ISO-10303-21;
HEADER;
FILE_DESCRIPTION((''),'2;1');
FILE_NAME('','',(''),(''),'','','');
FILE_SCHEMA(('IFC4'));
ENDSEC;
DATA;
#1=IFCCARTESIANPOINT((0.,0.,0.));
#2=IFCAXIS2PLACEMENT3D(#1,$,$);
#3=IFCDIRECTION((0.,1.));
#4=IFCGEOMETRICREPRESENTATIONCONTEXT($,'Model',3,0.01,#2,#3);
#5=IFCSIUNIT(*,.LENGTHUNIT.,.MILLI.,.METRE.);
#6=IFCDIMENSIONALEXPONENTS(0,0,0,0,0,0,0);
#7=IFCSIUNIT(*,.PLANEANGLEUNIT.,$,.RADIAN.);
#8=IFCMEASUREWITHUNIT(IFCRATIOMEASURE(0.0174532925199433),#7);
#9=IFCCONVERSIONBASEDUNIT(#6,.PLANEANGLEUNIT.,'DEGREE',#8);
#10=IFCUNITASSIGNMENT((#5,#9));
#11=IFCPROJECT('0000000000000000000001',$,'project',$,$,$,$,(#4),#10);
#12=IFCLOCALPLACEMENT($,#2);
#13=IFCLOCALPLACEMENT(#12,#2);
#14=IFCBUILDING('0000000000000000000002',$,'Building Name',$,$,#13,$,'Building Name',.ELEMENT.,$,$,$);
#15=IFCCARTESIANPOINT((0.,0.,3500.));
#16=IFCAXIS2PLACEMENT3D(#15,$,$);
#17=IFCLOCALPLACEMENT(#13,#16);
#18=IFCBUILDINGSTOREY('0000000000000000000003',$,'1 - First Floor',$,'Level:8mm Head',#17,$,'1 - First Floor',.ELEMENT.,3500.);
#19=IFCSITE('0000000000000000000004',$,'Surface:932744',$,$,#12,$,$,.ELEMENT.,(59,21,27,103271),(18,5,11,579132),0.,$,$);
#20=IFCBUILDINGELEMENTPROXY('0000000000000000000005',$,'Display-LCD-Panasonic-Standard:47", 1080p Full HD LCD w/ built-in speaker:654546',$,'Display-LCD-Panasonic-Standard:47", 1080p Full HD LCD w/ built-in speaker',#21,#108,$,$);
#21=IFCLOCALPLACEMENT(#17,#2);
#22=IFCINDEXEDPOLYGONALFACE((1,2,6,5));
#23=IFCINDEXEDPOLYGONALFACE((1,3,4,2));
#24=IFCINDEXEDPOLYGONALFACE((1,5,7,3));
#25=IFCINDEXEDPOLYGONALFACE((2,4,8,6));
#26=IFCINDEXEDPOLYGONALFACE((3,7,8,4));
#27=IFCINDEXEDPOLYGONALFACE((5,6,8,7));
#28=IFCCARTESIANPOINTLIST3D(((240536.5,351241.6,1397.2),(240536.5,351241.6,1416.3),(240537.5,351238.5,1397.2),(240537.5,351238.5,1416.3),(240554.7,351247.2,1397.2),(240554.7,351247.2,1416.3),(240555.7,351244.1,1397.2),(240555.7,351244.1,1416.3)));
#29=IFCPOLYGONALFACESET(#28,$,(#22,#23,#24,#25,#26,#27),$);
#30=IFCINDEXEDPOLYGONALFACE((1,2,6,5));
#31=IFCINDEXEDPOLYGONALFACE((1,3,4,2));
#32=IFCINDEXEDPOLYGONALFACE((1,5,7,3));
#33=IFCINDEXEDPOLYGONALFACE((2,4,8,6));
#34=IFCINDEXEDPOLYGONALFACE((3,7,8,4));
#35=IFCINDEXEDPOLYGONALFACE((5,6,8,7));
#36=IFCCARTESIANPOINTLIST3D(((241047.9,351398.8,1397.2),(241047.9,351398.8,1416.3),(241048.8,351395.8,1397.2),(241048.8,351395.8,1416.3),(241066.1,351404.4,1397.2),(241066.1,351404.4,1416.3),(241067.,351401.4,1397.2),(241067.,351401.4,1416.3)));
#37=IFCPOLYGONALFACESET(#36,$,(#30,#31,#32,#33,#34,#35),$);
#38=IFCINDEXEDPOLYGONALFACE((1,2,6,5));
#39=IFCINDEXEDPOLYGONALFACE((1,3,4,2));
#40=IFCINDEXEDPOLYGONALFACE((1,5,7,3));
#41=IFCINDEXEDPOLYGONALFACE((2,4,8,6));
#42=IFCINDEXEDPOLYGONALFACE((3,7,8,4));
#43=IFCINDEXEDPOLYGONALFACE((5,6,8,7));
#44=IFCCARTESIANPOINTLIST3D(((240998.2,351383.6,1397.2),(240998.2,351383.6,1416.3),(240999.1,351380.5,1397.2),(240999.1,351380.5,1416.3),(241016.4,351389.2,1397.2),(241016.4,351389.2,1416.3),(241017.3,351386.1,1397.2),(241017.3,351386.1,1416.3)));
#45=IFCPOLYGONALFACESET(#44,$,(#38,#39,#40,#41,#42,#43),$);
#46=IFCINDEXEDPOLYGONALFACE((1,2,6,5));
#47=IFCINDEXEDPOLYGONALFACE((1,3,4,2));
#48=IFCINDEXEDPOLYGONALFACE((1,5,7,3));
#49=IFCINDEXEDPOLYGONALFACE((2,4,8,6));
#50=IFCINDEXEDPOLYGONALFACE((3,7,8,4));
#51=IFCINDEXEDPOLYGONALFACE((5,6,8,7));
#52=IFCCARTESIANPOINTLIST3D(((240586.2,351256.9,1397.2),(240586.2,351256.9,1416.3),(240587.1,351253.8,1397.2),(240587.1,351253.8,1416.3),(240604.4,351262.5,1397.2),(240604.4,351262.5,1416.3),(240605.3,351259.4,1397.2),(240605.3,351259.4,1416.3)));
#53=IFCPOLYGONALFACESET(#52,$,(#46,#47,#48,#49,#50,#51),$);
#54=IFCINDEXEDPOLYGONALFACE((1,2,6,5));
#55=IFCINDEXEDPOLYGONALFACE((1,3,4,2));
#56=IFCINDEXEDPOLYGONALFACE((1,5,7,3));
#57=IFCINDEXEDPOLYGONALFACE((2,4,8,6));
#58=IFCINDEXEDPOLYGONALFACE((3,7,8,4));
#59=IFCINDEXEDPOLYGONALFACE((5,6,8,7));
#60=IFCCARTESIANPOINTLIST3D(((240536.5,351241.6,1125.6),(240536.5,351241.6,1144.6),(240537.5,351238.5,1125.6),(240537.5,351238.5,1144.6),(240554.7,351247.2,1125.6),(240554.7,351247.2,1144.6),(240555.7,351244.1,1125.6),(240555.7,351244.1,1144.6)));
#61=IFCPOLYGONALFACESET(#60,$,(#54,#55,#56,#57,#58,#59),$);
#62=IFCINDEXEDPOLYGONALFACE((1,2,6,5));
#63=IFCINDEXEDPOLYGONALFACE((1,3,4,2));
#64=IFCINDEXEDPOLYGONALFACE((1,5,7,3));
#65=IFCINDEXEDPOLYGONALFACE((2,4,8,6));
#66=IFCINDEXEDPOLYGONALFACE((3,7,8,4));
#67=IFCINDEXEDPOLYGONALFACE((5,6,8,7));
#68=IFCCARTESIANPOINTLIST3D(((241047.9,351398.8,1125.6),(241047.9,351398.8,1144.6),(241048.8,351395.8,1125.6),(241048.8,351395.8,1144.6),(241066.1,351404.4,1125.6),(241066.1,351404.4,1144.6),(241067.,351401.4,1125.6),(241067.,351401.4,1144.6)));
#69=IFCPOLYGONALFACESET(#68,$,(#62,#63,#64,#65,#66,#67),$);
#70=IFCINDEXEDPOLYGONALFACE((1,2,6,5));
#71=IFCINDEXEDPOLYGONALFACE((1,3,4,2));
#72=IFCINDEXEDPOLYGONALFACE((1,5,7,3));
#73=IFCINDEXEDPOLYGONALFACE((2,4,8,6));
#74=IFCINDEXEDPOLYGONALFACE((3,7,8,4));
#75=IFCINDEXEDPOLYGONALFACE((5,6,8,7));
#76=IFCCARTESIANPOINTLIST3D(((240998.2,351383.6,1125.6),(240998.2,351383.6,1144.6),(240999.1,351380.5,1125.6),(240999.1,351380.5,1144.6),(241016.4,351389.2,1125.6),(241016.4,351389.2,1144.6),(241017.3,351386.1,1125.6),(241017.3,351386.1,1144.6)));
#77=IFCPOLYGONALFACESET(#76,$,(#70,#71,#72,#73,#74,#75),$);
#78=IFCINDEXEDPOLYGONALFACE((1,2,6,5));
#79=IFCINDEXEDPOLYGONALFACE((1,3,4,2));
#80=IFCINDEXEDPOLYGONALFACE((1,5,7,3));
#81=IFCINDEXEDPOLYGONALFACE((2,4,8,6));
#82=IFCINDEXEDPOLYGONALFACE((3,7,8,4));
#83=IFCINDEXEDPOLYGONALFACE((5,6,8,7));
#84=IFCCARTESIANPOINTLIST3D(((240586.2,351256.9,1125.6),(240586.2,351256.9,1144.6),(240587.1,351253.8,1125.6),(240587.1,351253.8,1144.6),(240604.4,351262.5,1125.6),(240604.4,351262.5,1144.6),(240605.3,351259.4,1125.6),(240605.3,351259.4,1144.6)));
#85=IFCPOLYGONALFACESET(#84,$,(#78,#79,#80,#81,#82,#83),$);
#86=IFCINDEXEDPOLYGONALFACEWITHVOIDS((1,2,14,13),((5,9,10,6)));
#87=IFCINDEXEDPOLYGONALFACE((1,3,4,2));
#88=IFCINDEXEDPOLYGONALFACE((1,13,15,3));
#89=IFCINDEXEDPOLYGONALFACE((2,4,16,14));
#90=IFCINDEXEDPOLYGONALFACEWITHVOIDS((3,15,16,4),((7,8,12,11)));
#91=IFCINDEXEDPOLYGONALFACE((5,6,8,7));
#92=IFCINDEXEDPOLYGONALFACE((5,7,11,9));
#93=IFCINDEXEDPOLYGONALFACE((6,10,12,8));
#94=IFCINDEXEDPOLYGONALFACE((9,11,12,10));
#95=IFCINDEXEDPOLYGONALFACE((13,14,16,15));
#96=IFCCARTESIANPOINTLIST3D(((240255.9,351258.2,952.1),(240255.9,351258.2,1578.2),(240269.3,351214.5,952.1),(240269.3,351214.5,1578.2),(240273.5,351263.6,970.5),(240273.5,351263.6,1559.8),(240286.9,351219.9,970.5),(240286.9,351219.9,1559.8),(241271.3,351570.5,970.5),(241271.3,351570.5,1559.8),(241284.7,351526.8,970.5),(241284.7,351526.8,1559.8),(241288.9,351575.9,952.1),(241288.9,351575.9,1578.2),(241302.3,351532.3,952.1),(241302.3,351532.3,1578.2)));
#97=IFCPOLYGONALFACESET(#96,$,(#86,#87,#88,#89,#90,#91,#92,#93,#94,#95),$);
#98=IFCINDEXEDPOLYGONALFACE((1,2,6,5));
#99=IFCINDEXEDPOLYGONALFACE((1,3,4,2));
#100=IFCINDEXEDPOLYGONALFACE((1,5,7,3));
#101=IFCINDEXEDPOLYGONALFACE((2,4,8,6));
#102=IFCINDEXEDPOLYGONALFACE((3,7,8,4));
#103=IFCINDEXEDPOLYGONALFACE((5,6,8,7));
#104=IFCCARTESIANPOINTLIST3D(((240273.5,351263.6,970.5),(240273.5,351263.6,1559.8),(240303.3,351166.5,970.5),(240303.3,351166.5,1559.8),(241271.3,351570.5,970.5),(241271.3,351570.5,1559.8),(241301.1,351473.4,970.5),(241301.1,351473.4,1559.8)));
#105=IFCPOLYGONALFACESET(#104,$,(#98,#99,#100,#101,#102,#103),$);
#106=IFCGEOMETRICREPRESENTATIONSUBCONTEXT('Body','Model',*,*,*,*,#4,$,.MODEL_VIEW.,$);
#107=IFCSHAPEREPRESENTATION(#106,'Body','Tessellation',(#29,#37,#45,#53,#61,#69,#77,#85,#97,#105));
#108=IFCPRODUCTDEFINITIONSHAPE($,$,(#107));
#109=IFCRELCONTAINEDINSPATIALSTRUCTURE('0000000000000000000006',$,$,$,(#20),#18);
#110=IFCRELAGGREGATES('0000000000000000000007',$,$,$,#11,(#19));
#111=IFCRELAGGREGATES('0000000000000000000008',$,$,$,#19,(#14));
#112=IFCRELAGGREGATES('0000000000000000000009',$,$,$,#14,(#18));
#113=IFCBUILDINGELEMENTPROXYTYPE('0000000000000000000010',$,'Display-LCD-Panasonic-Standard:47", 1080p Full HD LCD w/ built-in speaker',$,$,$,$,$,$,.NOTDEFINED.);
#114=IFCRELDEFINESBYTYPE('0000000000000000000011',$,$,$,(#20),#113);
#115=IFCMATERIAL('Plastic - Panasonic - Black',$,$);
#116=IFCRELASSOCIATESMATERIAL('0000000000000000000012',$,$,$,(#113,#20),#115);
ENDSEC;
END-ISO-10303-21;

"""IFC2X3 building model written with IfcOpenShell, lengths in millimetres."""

from ifc_helpers import new_model, entity, si_unit, converted_unit, direction, frame, frame_2d, origin, origin_2d_with_axis, place, context, subcontext, project, spatial, polyline, rectangle, outline, extrude, source, transform, mapped, material, type_object, type_shapes, element, save


model = new_model("IFC2X3")

# Units and contexts
model_context = context("Model", 3, precision=0.01, world=origin(), true_north=direction((0.0, 1.0)))
body_context = subcontext(model_context, "Body", "Model", "MODEL_VIEW")
ifc_project = project(units=[si_unit("LENGTHUNIT", "METRE", prefix="MILLI"), converted_unit("PLANEANGLEUNIT", "DEGREE", entity("IfcRatioMeasure", 0.0174532925199433), si_unit("PLANEANGLEUNIT", "RADIAN"), dimensions=[0, 0, 0, 0, 0, 0, 0])], contexts=[model_context])

# Site, building, storey
site_placement = place(None, origin())
site = spatial("IfcSite", under=ifc_project, at=site_placement, Name="Surface:932744", CompositionType="ELEMENT", RefLatitude=(59, 21, 27, 103271), RefLongitude=(18, 5, 11, 579132), RefElevation=0.0)
building_placement = place(site_placement, origin())
building = spatial("IfcBuilding", under=site, at=building_placement, Name="Building Name", LongName="Building Name", CompositionType="ELEMENT")
storey_placement = place(building_placement, frame((0.0, 0.0, 3500.0)))
storey = spatial("IfcBuildingStorey", under=building, at=storey_placement, Name="1 - First Floor", ObjectType="Level:8mm Head", LongName="1 - First Floor", CompositionType="ELEMENT", Elevation=3500.0)

# Building element proxy
ifc_material_1 = material(Name="Plastic - Panasonic - Black")
building_element_proxy_type_1 = type_object("IfcBuildingElementProxyType", Name="Display-LCD-Panasonic-Standard:47\", 1080p Full HD LCD w/ built-in speaker", PredefinedType="NOTDEFINED", material=ifc_material_1)
shared_shape_1 = source(origin(), body_context, "Body", "SweptSolid", [
    extrude(rectangle(XDim=19.0, YDim=19.1, at=origin_2d_with_axis()), frame((267.5, 187.5, 0.0), z_axis=(0.0, 0.0, 1.0), x_axis=(0.0, 1.0, 0.0)), (0.0, 0.0, 1.0), 3.2),
    extrude(rectangle(XDim=19.0, YDim=19.1, at=origin_2d_with_axis()), frame((-267.5, 187.5, 0.0), z_axis=(0.0, 0.0, 1.0), x_axis=(0.0, 1.0, 0.0)), (0.0, 0.0, 1.0), 3.2),
    extrude(rectangle(XDim=19.0, YDim=19.0, at=origin_2d_with_axis()), frame((-215.5, 187.5, 0.0), z_axis=(0.0, 0.0, 1.0), x_axis=(0.0, 1.0, 0.0)), (0.0, 0.0, 1.0), 3.2),
    extrude(rectangle(XDim=19.0, YDim=19.0, at=frame_2d((0.0, 0.0), x_axis=(1.0, 0.0))), frame((215.5, 187.5, 0.0), z_axis=(0.0, 0.0, 1.0), x_axis=(0.0, 1.0, 0.0)), (0.0, 0.0, 1.0), 3.2),
    extrude(rectangle(XDim=19.0, YDim=19.1, at=frame_2d((0.0, 0.0), x_axis=(1.0, 0.0))), frame((267.5, -84.1, 0.0), z_axis=(0.0, 0.0, 1.0), x_axis=(0.0, 1.0, 0.0)), (0.0, 0.0, 1.0), 3.2),
    extrude(rectangle(XDim=19.0, YDim=19.1, at=frame_2d((0.0, 0.0), x_axis=(1.0, 0.0))), frame((-267.5, -84.1, 0.0), z_axis=(0.0, 0.0, 1.0), x_axis=(0.0, 1.0, 0.0)), (0.0, 0.0, 1.0), 3.2),
    extrude(rectangle(XDim=19.0, YDim=19.0, at=frame_2d((0.0, 0.0), x_axis=(1.0, 0.0))), frame((-215.5, -84.1, 0.0), z_axis=(0.0, 0.0, 1.0), x_axis=(0.0, 1.0, 0.0)), (0.0, 0.0, 1.0), 3.2),
    extrude(rectangle(XDim=19.0, YDim=19.0, at=frame_2d((0.0, 0.0), x_axis=(1.0, 0.0))), frame((215.5, -84.1, 0.0), z_axis=(0.0, 0.0, 1.0), x_axis=(0.0, 1.0, 0.0)), (0.0, 0.0, 1.0), 3.2),
    extrude(outline(polyline([(-313.1, -540.4), (313.1, -540.4), (313.1, 540.4), (-313.1, 540.4), (-313.1, -540.4)]), holes=[polyline([(294.6, -522.0), (-294.6, -522.0), (-294.6, 522.0), (294.6, 522.0), (294.6, -522.0)])]), frame((0.0, 46.0, 55.9), z_axis=(0.0, 0.0, 1.0), x_axis=(0.0, 1.0, 0.0)), (0.0, 0.0, 1.0), 45.7),
    extrude(rectangle(XDim=1043.9, YDim=589.3, at=frame_2d((0.0, 0.0), x_axis=(1.0, 0.0))), frame((0.0, 46.0, 0.0), z_axis=(0.0, 0.0, 1.0), x_axis=(-1.0, 0.0, 0.0)), (0.0, 0.0, 1.0), 101.6),
])
type_shapes(building_element_proxy_type_1, [shared_shape_1])
proxy_1_placement = place(storey_placement, frame((240802.2, 351320.0, 1219.2), z_axis=(-0.29398, 0.955811, 0.0), x_axis=(-0.955811, -0.29398, 0.0)))
element("IfcBuildingElementProxy", 1, at=proxy_1_placement, inside=storey, type_object=building_element_proxy_type_1, material=ifc_material_1, Name="Display-LCD-Panasonic-Standard:47\", 1080p Full HD LCD w/ built-in speaker:654546", ObjectType="Display-LCD-Panasonic-Standard:47\", 1080p Full HD LCD w/ built-in speaker", context=body_context, shape_type="MappedRepresentation", body=[
    mapped(shared_shape_1, transform((0.0, 0.0, 0.0), scale=1.0)),
])

save(model, "model.ifc")
